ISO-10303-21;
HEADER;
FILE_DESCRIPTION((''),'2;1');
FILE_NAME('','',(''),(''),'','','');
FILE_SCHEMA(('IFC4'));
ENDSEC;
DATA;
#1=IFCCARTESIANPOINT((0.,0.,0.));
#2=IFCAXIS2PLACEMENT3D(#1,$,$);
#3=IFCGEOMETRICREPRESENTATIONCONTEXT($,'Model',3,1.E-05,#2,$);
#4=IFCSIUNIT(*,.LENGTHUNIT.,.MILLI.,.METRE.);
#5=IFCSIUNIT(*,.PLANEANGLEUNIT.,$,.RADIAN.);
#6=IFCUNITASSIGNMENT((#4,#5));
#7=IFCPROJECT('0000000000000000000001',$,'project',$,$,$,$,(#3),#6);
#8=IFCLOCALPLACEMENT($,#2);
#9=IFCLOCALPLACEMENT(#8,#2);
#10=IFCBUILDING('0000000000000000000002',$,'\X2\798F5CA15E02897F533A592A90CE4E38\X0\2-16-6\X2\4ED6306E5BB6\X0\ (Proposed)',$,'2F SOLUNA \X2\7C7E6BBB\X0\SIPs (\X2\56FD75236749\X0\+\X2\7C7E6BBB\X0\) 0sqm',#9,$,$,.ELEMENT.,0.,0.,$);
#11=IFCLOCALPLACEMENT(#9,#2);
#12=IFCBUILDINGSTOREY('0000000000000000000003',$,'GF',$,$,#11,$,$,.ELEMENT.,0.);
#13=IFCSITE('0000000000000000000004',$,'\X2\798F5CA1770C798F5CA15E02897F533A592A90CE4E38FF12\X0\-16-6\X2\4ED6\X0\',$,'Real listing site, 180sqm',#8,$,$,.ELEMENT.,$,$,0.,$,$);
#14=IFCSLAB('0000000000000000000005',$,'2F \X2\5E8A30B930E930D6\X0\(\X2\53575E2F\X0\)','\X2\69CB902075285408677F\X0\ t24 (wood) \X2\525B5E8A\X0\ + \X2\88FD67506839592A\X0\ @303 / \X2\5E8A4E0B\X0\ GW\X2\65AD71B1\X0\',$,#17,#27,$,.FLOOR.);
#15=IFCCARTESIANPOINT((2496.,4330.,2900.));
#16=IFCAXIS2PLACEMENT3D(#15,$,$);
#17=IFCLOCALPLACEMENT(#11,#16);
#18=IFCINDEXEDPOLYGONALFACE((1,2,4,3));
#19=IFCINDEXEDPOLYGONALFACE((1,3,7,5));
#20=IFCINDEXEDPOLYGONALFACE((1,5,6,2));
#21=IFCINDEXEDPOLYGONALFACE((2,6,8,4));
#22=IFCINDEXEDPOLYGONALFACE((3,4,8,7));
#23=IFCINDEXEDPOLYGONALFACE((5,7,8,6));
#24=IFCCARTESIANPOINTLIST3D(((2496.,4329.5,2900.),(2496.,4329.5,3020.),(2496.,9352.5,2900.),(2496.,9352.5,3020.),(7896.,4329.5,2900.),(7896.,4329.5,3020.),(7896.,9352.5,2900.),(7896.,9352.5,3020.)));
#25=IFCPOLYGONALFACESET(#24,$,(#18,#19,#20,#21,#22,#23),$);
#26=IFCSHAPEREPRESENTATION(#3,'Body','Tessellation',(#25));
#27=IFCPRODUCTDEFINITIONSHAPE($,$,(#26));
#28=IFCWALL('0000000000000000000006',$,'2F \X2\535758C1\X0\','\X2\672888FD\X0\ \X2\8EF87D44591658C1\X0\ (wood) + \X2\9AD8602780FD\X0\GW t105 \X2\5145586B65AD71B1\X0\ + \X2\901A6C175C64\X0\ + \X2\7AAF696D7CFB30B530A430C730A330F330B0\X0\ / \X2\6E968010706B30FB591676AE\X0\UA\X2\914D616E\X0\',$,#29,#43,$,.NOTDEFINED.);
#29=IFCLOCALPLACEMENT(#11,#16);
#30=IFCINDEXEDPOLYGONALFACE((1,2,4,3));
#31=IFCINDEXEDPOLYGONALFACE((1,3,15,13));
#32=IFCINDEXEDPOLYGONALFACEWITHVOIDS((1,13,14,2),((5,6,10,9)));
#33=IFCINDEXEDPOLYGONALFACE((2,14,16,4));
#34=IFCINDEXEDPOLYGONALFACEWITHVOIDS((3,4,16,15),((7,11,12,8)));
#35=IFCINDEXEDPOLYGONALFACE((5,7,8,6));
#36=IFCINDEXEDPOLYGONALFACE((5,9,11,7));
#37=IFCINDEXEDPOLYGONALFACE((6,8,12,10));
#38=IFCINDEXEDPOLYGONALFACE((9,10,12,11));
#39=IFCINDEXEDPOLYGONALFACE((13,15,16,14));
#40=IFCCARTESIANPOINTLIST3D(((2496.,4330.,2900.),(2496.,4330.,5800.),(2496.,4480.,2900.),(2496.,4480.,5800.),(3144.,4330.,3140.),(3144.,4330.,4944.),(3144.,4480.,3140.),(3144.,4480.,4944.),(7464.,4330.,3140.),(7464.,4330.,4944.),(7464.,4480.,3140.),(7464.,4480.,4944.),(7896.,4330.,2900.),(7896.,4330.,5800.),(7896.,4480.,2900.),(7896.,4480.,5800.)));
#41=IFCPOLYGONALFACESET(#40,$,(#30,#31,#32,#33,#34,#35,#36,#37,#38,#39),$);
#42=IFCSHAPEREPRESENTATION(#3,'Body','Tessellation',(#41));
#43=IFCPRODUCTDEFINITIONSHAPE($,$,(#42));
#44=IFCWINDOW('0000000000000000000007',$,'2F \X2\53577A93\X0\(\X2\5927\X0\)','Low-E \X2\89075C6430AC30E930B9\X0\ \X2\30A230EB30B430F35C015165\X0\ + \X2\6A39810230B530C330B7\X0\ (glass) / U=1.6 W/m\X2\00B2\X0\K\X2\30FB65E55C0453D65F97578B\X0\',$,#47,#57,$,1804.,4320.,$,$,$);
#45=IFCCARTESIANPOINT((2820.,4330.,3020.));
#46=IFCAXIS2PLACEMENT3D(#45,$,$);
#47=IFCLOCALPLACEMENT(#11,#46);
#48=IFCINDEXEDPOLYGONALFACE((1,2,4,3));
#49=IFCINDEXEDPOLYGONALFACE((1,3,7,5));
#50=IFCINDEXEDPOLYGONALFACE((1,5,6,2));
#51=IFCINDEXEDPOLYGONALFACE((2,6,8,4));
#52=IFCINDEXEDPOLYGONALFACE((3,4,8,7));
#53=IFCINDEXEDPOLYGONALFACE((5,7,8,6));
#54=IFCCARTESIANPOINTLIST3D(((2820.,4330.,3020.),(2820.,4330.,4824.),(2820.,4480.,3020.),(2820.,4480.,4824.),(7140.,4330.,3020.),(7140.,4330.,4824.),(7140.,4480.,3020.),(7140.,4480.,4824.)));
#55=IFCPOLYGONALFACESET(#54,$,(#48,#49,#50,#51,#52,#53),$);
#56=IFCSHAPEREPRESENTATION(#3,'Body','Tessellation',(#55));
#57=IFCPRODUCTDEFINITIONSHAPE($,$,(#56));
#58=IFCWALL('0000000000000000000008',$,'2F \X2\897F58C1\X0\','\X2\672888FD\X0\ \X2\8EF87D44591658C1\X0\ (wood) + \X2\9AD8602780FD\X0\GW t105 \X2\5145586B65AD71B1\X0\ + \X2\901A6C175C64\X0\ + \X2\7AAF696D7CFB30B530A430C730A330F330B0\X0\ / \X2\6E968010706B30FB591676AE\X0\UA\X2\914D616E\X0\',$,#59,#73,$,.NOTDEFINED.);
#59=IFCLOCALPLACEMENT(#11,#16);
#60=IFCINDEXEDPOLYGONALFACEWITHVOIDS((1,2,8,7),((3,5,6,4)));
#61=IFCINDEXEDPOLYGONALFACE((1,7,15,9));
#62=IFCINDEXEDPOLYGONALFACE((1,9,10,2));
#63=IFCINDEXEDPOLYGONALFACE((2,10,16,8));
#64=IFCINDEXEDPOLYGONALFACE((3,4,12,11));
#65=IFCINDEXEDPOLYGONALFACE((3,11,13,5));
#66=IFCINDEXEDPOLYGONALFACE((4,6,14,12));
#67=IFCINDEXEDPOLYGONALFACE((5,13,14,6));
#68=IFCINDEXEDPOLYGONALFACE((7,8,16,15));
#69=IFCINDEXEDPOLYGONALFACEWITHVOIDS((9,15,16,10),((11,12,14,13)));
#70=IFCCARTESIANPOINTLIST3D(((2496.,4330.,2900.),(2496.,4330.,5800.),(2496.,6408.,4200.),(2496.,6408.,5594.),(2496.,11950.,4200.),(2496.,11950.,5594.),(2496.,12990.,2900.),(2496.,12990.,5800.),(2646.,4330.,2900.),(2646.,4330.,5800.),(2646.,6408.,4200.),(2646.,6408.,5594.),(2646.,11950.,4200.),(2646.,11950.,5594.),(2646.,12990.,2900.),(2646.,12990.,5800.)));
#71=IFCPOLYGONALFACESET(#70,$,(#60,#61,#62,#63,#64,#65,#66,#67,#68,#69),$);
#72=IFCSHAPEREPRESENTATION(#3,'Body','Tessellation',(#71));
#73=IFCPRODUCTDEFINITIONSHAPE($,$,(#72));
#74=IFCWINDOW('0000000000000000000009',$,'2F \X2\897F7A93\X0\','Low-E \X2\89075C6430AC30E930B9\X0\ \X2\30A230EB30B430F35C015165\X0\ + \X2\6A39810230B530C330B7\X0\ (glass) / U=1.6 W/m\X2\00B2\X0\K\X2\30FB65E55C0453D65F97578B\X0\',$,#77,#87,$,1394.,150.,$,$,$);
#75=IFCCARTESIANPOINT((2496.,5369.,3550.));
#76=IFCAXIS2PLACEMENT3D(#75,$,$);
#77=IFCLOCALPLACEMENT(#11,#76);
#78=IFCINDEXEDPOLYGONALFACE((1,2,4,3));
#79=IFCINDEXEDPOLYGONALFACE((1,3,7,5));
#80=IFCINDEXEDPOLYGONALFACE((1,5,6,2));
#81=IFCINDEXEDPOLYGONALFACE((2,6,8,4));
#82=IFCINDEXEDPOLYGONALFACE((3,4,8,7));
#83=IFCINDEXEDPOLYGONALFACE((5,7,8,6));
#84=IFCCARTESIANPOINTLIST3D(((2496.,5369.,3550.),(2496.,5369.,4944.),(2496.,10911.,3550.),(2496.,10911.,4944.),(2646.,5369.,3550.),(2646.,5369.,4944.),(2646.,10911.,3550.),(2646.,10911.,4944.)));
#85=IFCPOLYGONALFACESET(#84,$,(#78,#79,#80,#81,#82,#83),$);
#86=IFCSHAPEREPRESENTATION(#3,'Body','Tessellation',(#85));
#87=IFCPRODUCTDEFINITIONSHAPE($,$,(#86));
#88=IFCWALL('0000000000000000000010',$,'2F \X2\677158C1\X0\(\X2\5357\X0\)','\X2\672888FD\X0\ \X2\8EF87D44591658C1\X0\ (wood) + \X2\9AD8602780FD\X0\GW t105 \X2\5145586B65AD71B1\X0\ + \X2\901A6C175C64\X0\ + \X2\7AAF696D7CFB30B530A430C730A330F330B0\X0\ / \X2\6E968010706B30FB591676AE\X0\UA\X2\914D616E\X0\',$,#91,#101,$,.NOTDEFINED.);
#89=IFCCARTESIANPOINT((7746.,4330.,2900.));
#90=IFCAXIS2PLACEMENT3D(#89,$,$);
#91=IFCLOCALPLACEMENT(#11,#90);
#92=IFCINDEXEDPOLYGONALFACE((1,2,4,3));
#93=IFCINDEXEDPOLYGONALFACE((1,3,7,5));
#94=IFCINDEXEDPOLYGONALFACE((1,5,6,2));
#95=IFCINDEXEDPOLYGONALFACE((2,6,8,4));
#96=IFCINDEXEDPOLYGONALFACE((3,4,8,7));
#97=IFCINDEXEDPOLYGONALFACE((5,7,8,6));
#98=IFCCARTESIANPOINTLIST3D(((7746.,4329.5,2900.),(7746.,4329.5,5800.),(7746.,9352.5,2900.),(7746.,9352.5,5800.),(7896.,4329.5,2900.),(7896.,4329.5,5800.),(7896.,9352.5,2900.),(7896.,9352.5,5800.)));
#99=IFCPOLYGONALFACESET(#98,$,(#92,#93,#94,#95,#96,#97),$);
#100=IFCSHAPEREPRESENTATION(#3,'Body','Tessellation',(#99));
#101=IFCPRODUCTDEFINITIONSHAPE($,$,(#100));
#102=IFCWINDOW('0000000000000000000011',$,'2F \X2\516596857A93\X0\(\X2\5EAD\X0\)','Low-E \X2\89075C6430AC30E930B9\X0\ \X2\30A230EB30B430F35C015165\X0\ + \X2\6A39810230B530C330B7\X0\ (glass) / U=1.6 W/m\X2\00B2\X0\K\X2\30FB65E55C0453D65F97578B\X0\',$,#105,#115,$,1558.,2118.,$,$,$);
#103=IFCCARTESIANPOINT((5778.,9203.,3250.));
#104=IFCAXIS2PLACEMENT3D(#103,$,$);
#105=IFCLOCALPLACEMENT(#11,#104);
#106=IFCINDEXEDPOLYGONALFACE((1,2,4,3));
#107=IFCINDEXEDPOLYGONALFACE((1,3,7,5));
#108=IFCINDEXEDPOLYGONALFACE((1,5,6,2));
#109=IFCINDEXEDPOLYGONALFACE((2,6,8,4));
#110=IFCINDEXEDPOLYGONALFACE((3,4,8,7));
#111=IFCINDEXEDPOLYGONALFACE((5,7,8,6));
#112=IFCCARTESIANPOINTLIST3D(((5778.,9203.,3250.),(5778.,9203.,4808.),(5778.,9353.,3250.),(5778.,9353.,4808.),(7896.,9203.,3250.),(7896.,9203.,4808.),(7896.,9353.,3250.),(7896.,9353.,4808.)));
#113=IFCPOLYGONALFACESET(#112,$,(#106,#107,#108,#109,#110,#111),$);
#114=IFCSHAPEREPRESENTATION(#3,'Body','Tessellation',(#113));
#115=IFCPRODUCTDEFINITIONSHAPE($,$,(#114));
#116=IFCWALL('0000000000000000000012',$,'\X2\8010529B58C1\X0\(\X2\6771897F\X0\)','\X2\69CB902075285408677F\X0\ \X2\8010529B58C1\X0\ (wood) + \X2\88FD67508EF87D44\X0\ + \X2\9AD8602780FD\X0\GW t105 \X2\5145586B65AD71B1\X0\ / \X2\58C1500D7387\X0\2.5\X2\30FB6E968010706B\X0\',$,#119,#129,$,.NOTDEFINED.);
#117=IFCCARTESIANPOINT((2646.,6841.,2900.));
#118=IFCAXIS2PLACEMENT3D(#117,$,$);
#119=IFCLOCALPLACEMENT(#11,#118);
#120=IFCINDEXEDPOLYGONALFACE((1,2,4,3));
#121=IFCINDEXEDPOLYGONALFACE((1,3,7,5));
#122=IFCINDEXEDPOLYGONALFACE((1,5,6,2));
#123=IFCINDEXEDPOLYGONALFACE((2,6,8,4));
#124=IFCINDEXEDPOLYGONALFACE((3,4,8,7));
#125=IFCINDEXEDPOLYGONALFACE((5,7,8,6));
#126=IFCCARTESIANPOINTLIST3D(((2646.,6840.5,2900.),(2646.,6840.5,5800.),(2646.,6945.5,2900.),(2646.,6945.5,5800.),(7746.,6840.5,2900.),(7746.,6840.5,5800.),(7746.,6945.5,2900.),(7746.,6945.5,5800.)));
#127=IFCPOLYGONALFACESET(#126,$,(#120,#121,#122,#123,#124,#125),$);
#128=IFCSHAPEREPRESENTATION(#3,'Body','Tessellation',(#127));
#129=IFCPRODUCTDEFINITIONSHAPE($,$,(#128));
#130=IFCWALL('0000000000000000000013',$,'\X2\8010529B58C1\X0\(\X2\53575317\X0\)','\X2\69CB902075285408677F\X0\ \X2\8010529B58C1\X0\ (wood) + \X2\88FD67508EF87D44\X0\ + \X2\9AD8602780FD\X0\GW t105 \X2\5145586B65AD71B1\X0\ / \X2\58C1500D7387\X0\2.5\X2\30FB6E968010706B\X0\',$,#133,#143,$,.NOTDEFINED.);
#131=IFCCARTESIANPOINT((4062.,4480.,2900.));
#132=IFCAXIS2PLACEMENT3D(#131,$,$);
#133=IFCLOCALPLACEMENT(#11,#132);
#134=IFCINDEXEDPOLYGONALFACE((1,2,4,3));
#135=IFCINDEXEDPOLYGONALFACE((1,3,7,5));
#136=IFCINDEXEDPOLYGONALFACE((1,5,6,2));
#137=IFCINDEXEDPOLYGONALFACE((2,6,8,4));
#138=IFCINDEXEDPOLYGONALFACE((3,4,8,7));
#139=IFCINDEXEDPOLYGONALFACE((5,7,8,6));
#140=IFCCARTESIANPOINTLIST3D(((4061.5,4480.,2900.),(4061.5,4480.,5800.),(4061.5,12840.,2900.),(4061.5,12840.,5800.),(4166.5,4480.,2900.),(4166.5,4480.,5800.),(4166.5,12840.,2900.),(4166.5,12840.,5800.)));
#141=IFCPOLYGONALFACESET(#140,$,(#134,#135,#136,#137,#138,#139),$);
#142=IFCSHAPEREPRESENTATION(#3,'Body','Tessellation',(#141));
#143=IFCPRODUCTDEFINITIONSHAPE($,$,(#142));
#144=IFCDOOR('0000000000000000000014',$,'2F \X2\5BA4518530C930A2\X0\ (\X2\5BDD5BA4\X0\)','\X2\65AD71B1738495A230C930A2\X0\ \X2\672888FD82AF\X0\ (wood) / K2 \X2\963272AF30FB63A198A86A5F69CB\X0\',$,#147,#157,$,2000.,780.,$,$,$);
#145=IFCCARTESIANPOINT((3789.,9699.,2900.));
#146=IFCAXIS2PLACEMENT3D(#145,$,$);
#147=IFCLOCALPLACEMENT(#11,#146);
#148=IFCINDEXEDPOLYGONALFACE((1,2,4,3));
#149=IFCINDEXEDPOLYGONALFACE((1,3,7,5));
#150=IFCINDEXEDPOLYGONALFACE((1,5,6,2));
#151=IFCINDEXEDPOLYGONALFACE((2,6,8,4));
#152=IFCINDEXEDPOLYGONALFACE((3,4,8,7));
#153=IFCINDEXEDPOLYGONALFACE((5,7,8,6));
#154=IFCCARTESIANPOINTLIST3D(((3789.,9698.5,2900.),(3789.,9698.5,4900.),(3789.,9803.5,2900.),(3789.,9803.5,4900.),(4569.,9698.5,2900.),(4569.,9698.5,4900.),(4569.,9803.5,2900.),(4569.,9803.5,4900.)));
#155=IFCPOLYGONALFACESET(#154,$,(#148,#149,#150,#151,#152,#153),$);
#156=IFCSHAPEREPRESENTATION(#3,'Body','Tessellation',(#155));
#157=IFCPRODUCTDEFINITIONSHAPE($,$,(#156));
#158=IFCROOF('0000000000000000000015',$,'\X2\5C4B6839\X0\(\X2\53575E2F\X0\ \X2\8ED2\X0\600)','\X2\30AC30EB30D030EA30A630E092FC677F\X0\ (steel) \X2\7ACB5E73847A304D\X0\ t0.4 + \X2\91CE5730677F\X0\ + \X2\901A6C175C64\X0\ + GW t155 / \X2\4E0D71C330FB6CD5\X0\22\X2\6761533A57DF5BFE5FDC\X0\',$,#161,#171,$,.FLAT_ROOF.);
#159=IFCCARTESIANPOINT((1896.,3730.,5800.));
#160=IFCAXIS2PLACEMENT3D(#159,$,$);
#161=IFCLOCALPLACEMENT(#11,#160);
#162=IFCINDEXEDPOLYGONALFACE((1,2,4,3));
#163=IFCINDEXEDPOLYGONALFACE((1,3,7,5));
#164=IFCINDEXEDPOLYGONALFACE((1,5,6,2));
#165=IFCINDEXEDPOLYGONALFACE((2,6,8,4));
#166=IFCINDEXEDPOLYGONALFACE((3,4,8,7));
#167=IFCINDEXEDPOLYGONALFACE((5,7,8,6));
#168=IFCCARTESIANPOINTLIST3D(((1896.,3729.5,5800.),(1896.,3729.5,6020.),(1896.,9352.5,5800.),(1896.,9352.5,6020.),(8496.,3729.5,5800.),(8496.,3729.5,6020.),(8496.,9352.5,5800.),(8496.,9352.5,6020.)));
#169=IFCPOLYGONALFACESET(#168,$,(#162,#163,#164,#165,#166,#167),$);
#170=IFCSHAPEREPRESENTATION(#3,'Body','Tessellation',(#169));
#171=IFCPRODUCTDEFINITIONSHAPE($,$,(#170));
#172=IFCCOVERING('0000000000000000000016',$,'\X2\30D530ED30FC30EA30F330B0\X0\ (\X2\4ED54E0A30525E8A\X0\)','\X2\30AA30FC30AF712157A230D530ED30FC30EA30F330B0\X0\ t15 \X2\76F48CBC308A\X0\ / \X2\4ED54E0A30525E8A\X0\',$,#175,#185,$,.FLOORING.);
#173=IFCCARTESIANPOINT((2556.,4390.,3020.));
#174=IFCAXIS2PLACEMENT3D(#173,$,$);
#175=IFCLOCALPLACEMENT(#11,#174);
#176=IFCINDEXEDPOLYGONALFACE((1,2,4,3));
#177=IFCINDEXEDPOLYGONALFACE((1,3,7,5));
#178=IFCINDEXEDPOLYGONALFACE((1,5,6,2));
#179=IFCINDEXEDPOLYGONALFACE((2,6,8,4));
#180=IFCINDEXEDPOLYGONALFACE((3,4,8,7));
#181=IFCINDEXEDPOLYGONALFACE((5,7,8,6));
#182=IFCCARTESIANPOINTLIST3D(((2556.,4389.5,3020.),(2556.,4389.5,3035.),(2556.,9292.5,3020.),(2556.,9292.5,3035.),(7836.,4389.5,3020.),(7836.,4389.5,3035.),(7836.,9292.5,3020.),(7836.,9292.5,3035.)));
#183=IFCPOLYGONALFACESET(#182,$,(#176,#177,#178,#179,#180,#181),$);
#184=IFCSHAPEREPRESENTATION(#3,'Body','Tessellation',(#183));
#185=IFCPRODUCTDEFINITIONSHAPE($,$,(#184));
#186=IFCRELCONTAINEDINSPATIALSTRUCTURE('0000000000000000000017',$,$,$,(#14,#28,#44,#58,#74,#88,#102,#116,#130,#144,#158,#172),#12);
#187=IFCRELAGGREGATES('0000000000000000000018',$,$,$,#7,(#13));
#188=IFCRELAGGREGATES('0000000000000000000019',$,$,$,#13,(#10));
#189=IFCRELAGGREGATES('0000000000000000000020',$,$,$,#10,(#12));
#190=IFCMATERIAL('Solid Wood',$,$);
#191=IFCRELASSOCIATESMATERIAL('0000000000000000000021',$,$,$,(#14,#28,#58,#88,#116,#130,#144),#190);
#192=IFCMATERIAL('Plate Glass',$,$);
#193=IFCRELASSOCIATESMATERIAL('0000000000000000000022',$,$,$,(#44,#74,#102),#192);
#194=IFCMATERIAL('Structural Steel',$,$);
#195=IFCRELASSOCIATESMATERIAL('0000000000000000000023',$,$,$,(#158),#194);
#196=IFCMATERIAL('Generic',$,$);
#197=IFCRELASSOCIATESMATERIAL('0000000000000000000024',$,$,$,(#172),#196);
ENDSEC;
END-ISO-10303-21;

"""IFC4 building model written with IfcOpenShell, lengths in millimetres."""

from ifc_helpers import new_model, si_unit, frame, frame_2d, origin, place, context, project, spatial, rectangle, extrude, material, element, fill, save


model = new_model("IFC4")

# Units and contexts
model_context = context("Model", 3, precision=1e-05, world=origin())
ifc_project = project(units=[si_unit("LENGTHUNIT", "METRE", prefix="MILLI"), si_unit("PLANEANGLEUNIT", "RADIAN")], contexts=[model_context])

# Site, building, storey
site_placement = place(None, origin())
site = spatial("IfcSite", under=ifc_project, at=site_placement, Name="福岡県福岡市西区太郎丸２-16-6他", ObjectType="Real listing site, 180sqm", CompositionType="ELEMENT", RefElevation=0.0)
building_placement = place(site_placement, origin())
building = spatial("IfcBuilding", under=site, at=building_placement, Name="福岡市西区太郎丸2-16-6他の家 (Proposed)", ObjectType="2F SOLUNA 籾殻SIPs (国産杉+籾殻) 0sqm", CompositionType="ELEMENT", ElevationOfRefHeight=0.0, ElevationOfTerrain=0.0)
storey_placement = place(building_placement, origin())
storey = spatial("IfcBuildingStorey", under=building, at=storey_placement, Name="GF", CompositionType="ELEMENT", Elevation=0.0)

# Slab
ifc_material_1 = material(Name="Solid Wood")
slab_placement = place(storey_placement, frame((2496.0, 4330.0, 2900.0)))
element("IfcSlab", 1, at=slab_placement, inside=storey, material=ifc_material_1, Name="2F 床スラブ(南帯)", Description="構造用合板 t24 (wood) 剛床 + 製材根太 @303 / 床下 GW断熱", PredefinedType="FLOOR", context=model_context, shape_type="SweptSolid", body=[
    extrude(rectangle(XDim=5400.0, YDim=5023.0, at=frame_2d((2700.0, 2511.0))), frame((2496.0, 4330.0, 2900.0)), (0.0, 0.0, 1.0), 120.0),
])

# Walls, openings, windows
wall_1_placement = place(storey_placement, frame((2496.0, 4330.0, 2900.0)))
wall_1 = element("IfcWall", 2, at=wall_1_placement, inside=storey, material=ifc_material_1, Name="2F 南壁", Description="木製 軸組外壁 (wood) + 高性能GW t105 充填断熱 + 通気層 + 窯業系サイディング / 準耐火・外皮UA配慮", PredefinedType="NOTDEFINED", context=model_context, shape_type="SweptSolid", body=[
    extrude(rectangle(XDim=5400.0, YDim=150.0, at=frame_2d((2700.0, 75.0))), frame((2496.0, 4330.0, 2900.0)), (0.0, 0.0, 1.0), 2900.0),
])
opening_1_placement = place(storey_placement, frame((2820.0, 4330.0, 3020.0)))
opening_1 = element("IfcOpeningElement", 3, at=opening_1_placement, cuts=wall_1, PredefinedType="NOTDEFINED", context=model_context, shape_type="SweptSolid", body=[
    extrude(rectangle(XDim=4320.0, YDim=150.0, at=frame_2d((2160.0, 75.0))), frame((2820.0, 4330.0, 3020.0)), (0.0, 0.0, 1.0), 1804.0),
])
ifc_material_2 = material(Name="Plate Glass")
window_1_placement = place(storey_placement, frame((2820.0, 4330.0, 3020.0)))
window_1 = element("IfcWindow", 4, at=window_1_placement, inside=storey, material=ifc_material_2, Name="2F 南窓(大)", Description="Low-E 複層ガラス アルゴン封入 + 樹脂サッシ (glass) / U=1.6 W/m²K・日射取得型", OverallHeight=1804.0, OverallWidth=4320.0, context=model_context, shape_type="SweptSolid", body=[
    extrude(rectangle(XDim=4320.0, YDim=150.0, at=frame_2d((2160.0, 75.0))), frame((2820.0, 4330.0, 3020.0)), (0.0, 0.0, 1.0), 1804.0),
])
fill(opening_1, window_1)
wall_2_placement = place(storey_placement, frame((2496.0, 4330.0, 2900.0)))
wall_2 = element("IfcWall", 5, at=wall_2_placement, inside=storey, material=ifc_material_1, Name="2F 西壁", Description="木製 軸組外壁 (wood) + 高性能GW t105 充填断熱 + 通気層 + 窯業系サイディング / 準耐火・外皮UA配慮", PredefinedType="NOTDEFINED", context=model_context, shape_type="SweptSolid", body=[
    extrude(rectangle(XDim=150.0, YDim=8660.0, at=frame_2d((75.0, 4330.0))), frame((2496.0, 4330.0, 2900.0)), (0.0, 0.0, 1.0), 2900.0),
])
opening_2_placement = place(storey_placement, frame((2496.0, 5369.0, 3550.0)))
opening_2 = element("IfcOpeningElement", 6, at=opening_2_placement, cuts=wall_2, PredefinedType="NOTDEFINED", context=model_context, shape_type="SweptSolid", body=[
    extrude(rectangle(XDim=150.0, YDim=5542.0, at=frame_2d((75.0, 2771.0))), frame((2496.0, 5369.0, 3550.0)), (0.0, 0.0, 1.0), 1394.0),
])
window_2_placement = place(storey_placement, frame((2496.0, 5369.0, 3550.0)))
window_2 = element("IfcWindow", 7, at=window_2_placement, inside=storey, material=ifc_material_2, Name="2F 西窓", Description="Low-E 複層ガラス アルゴン封入 + 樹脂サッシ (glass) / U=1.6 W/m²K・日射取得型", OverallHeight=1394.0, OverallWidth=150.0, context=model_context, shape_type="SweptSolid", body=[
    extrude(rectangle(XDim=150.0, YDim=5542.0, at=frame_2d((75.0, 2771.0))), frame((2496.0, 5369.0, 3550.0)), (0.0, 0.0, 1.0), 1394.0),
])
fill(opening_2, window_2)
wall_3_placement = place(storey_placement, frame((7746.0, 4330.0, 2900.0)))
wall_3 = element("IfcWall", 8, at=wall_3_placement, inside=storey, material=ifc_material_1, Name="2F 東壁(南)", Description="木製 軸組外壁 (wood) + 高性能GW t105 充填断熱 + 通気層 + 窯業系サイディング / 準耐火・外皮UA配慮", PredefinedType="NOTDEFINED", context=model_context, shape_type="SweptSolid", body=[
    extrude(rectangle(XDim=150.0, YDim=5023.0, at=frame_2d((75.0, 2511.0))), frame((7746.0, 4330.0, 2900.0)), (0.0, 0.0, 1.0), 2900.0),
])
opening_3_placement = place(storey_placement, frame((5778.0, 9203.0, 3250.0)))
opening_3 = element("IfcOpeningElement", 9, at=opening_3_placement, cuts=wall_3, PredefinedType="NOTDEFINED", context=model_context, shape_type="SweptSolid", body=[
    extrude(rectangle(XDim=2118.0, YDim=150.0, at=frame_2d((1059.0, 75.0))), frame((5778.0, 9203.0, 3250.0)), (0.0, 0.0, 1.0), 1558.0),
])
window_3_placement = place(storey_placement, frame((5778.0, 9203.0, 3250.0)))
window_3 = element("IfcWindow", 10, at=window_3_placement, inside=storey, material=ifc_material_2, Name="2F 入隅窓(庭)", Description="Low-E 複層ガラス アルゴン封入 + 樹脂サッシ (glass) / U=1.6 W/m²K・日射取得型", OverallHeight=1558.0, OverallWidth=2118.0, context=model_context, shape_type="SweptSolid", body=[
    extrude(rectangle(XDim=2118.0, YDim=150.0, at=frame_2d((1059.0, 75.0))), frame((5778.0, 9203.0, 3250.0)), (0.0, 0.0, 1.0), 1558.0),
])
fill(opening_3, window_3)

# Wall
wall_4_placement = place(storey_placement, frame((2646.0, 6841.0, 2900.0)))
element("IfcWall", 11, at=wall_4_placement, inside=storey, material=ifc_material_1, Name="耐力壁(東西)", Description="構造用合板 耐力壁 (wood) + 製材軸組 + 高性能GW t105 充填断熱 / 壁倍率2.5・準耐火", PredefinedType="NOTDEFINED", context=model_context, shape_type="SweptSolid", body=[
    extrude(rectangle(XDim=5100.0, YDim=105.0, at=frame_2d((2550.0, 52.0))), frame((2646.0, 6841.0, 2900.0)), (0.0, 0.0, 1.0), 2900.0),
])

# Wall, opening, door
wall_5_placement = place(storey_placement, frame((4062.0, 4480.0, 2900.0)))
wall_5 = element("IfcWall", 12, at=wall_5_placement, inside=storey, material=ifc_material_1, Name="耐力壁(南北)", Description="構造用合板 耐力壁 (wood) + 製材軸組 + 高性能GW t105 充填断熱 / 壁倍率2.5・準耐火", PredefinedType="NOTDEFINED", context=model_context, shape_type="SweptSolid", body=[
    extrude(rectangle(XDim=105.0, YDim=8360.0, at=frame_2d((52.0, 4180.0))), frame((4062.0, 4480.0, 2900.0)), (0.0, 0.0, 1.0), 2900.0),
])
opening_4_placement = place(storey_placement, frame((3789.0, 9699.0, 2900.0)))
opening_4 = element("IfcOpeningElement", 13, at=opening_4_placement, cuts=wall_5, PredefinedType="NOTDEFINED", context=model_context, shape_type="SweptSolid", body=[
    extrude(rectangle(XDim=780.0, YDim=105.0, at=frame_2d((390.0, 52.0))), frame((3789.0, 9699.0, 2900.0)), (0.0, 0.0, 1.0), 2000.0),
])
door_placement = place(storey_placement, frame((3789.0, 9699.0, 2900.0)))
door = element("IfcDoor", 14, at=door_placement, inside=storey, material=ifc_material_1, Name="2F 室内ドア (寝室)", Description="断熱玄関ドア 木製芯 (wood) / K2 防犯・採風機構", OverallHeight=2000.0, OverallWidth=780.0, context=model_context, shape_type="SweptSolid", body=[
    extrude(rectangle(XDim=780.0, YDim=105.0, at=frame_2d((390.0, 52.0))), frame((3789.0, 9699.0, 2900.0)), (0.0, 0.0, 1.0), 2000.0),
])
fill(opening_4, door)

# Roof
ifc_material_3 = material(Name="Structural Steel")
for number, where, name in (
    (15, (1896.0, 3730.0, 5800.0), "屋根(南帯 軒600)"),
):
    element("IfcRoof", number, at=place(storey_placement, frame(where)), inside=storey, material=ifc_material_3, Name=name, Description="ガルバリウム鋼板 (steel) 立平葺き t0.4 + 野地板 + 通気層 + GW t155 / 不燃・法22条区域対応", PredefinedType="FLAT_ROOF", context=model_context, shape_type="SweptSolid", body=[
        extrude(rectangle(XDim=6600.0, YDim=5623.0, at=frame_2d((3300.0, 2811.0))), frame((1896.0, 3730.0, 5800.0)), (0.0, 0.0, 1.0), 220.0),
    ])

# Covering
ifc_material_4 = material(Name="Generic")
covering_placement = place(storey_placement, frame((2556.0, 4390.0, 3020.0)))
element("IfcCovering", 16, at=covering_placement, inside=storey, material=ifc_material_4, Name="フローリング (仕上げ床)", Description="オーク無垢フローリング t15 直貼り / 仕上げ床", PredefinedType="FLOORING", context=model_context, shape_type="SweptSolid", body=[
    extrude(rectangle(XDim=5280.0, YDim=4903.0, at=frame_2d((2640.0, 2451.0))), frame((2556.0, 4390.0, 3020.0)), (0.0, 0.0, 1.0), 15.0),
])

save(model, "model.ifc")
